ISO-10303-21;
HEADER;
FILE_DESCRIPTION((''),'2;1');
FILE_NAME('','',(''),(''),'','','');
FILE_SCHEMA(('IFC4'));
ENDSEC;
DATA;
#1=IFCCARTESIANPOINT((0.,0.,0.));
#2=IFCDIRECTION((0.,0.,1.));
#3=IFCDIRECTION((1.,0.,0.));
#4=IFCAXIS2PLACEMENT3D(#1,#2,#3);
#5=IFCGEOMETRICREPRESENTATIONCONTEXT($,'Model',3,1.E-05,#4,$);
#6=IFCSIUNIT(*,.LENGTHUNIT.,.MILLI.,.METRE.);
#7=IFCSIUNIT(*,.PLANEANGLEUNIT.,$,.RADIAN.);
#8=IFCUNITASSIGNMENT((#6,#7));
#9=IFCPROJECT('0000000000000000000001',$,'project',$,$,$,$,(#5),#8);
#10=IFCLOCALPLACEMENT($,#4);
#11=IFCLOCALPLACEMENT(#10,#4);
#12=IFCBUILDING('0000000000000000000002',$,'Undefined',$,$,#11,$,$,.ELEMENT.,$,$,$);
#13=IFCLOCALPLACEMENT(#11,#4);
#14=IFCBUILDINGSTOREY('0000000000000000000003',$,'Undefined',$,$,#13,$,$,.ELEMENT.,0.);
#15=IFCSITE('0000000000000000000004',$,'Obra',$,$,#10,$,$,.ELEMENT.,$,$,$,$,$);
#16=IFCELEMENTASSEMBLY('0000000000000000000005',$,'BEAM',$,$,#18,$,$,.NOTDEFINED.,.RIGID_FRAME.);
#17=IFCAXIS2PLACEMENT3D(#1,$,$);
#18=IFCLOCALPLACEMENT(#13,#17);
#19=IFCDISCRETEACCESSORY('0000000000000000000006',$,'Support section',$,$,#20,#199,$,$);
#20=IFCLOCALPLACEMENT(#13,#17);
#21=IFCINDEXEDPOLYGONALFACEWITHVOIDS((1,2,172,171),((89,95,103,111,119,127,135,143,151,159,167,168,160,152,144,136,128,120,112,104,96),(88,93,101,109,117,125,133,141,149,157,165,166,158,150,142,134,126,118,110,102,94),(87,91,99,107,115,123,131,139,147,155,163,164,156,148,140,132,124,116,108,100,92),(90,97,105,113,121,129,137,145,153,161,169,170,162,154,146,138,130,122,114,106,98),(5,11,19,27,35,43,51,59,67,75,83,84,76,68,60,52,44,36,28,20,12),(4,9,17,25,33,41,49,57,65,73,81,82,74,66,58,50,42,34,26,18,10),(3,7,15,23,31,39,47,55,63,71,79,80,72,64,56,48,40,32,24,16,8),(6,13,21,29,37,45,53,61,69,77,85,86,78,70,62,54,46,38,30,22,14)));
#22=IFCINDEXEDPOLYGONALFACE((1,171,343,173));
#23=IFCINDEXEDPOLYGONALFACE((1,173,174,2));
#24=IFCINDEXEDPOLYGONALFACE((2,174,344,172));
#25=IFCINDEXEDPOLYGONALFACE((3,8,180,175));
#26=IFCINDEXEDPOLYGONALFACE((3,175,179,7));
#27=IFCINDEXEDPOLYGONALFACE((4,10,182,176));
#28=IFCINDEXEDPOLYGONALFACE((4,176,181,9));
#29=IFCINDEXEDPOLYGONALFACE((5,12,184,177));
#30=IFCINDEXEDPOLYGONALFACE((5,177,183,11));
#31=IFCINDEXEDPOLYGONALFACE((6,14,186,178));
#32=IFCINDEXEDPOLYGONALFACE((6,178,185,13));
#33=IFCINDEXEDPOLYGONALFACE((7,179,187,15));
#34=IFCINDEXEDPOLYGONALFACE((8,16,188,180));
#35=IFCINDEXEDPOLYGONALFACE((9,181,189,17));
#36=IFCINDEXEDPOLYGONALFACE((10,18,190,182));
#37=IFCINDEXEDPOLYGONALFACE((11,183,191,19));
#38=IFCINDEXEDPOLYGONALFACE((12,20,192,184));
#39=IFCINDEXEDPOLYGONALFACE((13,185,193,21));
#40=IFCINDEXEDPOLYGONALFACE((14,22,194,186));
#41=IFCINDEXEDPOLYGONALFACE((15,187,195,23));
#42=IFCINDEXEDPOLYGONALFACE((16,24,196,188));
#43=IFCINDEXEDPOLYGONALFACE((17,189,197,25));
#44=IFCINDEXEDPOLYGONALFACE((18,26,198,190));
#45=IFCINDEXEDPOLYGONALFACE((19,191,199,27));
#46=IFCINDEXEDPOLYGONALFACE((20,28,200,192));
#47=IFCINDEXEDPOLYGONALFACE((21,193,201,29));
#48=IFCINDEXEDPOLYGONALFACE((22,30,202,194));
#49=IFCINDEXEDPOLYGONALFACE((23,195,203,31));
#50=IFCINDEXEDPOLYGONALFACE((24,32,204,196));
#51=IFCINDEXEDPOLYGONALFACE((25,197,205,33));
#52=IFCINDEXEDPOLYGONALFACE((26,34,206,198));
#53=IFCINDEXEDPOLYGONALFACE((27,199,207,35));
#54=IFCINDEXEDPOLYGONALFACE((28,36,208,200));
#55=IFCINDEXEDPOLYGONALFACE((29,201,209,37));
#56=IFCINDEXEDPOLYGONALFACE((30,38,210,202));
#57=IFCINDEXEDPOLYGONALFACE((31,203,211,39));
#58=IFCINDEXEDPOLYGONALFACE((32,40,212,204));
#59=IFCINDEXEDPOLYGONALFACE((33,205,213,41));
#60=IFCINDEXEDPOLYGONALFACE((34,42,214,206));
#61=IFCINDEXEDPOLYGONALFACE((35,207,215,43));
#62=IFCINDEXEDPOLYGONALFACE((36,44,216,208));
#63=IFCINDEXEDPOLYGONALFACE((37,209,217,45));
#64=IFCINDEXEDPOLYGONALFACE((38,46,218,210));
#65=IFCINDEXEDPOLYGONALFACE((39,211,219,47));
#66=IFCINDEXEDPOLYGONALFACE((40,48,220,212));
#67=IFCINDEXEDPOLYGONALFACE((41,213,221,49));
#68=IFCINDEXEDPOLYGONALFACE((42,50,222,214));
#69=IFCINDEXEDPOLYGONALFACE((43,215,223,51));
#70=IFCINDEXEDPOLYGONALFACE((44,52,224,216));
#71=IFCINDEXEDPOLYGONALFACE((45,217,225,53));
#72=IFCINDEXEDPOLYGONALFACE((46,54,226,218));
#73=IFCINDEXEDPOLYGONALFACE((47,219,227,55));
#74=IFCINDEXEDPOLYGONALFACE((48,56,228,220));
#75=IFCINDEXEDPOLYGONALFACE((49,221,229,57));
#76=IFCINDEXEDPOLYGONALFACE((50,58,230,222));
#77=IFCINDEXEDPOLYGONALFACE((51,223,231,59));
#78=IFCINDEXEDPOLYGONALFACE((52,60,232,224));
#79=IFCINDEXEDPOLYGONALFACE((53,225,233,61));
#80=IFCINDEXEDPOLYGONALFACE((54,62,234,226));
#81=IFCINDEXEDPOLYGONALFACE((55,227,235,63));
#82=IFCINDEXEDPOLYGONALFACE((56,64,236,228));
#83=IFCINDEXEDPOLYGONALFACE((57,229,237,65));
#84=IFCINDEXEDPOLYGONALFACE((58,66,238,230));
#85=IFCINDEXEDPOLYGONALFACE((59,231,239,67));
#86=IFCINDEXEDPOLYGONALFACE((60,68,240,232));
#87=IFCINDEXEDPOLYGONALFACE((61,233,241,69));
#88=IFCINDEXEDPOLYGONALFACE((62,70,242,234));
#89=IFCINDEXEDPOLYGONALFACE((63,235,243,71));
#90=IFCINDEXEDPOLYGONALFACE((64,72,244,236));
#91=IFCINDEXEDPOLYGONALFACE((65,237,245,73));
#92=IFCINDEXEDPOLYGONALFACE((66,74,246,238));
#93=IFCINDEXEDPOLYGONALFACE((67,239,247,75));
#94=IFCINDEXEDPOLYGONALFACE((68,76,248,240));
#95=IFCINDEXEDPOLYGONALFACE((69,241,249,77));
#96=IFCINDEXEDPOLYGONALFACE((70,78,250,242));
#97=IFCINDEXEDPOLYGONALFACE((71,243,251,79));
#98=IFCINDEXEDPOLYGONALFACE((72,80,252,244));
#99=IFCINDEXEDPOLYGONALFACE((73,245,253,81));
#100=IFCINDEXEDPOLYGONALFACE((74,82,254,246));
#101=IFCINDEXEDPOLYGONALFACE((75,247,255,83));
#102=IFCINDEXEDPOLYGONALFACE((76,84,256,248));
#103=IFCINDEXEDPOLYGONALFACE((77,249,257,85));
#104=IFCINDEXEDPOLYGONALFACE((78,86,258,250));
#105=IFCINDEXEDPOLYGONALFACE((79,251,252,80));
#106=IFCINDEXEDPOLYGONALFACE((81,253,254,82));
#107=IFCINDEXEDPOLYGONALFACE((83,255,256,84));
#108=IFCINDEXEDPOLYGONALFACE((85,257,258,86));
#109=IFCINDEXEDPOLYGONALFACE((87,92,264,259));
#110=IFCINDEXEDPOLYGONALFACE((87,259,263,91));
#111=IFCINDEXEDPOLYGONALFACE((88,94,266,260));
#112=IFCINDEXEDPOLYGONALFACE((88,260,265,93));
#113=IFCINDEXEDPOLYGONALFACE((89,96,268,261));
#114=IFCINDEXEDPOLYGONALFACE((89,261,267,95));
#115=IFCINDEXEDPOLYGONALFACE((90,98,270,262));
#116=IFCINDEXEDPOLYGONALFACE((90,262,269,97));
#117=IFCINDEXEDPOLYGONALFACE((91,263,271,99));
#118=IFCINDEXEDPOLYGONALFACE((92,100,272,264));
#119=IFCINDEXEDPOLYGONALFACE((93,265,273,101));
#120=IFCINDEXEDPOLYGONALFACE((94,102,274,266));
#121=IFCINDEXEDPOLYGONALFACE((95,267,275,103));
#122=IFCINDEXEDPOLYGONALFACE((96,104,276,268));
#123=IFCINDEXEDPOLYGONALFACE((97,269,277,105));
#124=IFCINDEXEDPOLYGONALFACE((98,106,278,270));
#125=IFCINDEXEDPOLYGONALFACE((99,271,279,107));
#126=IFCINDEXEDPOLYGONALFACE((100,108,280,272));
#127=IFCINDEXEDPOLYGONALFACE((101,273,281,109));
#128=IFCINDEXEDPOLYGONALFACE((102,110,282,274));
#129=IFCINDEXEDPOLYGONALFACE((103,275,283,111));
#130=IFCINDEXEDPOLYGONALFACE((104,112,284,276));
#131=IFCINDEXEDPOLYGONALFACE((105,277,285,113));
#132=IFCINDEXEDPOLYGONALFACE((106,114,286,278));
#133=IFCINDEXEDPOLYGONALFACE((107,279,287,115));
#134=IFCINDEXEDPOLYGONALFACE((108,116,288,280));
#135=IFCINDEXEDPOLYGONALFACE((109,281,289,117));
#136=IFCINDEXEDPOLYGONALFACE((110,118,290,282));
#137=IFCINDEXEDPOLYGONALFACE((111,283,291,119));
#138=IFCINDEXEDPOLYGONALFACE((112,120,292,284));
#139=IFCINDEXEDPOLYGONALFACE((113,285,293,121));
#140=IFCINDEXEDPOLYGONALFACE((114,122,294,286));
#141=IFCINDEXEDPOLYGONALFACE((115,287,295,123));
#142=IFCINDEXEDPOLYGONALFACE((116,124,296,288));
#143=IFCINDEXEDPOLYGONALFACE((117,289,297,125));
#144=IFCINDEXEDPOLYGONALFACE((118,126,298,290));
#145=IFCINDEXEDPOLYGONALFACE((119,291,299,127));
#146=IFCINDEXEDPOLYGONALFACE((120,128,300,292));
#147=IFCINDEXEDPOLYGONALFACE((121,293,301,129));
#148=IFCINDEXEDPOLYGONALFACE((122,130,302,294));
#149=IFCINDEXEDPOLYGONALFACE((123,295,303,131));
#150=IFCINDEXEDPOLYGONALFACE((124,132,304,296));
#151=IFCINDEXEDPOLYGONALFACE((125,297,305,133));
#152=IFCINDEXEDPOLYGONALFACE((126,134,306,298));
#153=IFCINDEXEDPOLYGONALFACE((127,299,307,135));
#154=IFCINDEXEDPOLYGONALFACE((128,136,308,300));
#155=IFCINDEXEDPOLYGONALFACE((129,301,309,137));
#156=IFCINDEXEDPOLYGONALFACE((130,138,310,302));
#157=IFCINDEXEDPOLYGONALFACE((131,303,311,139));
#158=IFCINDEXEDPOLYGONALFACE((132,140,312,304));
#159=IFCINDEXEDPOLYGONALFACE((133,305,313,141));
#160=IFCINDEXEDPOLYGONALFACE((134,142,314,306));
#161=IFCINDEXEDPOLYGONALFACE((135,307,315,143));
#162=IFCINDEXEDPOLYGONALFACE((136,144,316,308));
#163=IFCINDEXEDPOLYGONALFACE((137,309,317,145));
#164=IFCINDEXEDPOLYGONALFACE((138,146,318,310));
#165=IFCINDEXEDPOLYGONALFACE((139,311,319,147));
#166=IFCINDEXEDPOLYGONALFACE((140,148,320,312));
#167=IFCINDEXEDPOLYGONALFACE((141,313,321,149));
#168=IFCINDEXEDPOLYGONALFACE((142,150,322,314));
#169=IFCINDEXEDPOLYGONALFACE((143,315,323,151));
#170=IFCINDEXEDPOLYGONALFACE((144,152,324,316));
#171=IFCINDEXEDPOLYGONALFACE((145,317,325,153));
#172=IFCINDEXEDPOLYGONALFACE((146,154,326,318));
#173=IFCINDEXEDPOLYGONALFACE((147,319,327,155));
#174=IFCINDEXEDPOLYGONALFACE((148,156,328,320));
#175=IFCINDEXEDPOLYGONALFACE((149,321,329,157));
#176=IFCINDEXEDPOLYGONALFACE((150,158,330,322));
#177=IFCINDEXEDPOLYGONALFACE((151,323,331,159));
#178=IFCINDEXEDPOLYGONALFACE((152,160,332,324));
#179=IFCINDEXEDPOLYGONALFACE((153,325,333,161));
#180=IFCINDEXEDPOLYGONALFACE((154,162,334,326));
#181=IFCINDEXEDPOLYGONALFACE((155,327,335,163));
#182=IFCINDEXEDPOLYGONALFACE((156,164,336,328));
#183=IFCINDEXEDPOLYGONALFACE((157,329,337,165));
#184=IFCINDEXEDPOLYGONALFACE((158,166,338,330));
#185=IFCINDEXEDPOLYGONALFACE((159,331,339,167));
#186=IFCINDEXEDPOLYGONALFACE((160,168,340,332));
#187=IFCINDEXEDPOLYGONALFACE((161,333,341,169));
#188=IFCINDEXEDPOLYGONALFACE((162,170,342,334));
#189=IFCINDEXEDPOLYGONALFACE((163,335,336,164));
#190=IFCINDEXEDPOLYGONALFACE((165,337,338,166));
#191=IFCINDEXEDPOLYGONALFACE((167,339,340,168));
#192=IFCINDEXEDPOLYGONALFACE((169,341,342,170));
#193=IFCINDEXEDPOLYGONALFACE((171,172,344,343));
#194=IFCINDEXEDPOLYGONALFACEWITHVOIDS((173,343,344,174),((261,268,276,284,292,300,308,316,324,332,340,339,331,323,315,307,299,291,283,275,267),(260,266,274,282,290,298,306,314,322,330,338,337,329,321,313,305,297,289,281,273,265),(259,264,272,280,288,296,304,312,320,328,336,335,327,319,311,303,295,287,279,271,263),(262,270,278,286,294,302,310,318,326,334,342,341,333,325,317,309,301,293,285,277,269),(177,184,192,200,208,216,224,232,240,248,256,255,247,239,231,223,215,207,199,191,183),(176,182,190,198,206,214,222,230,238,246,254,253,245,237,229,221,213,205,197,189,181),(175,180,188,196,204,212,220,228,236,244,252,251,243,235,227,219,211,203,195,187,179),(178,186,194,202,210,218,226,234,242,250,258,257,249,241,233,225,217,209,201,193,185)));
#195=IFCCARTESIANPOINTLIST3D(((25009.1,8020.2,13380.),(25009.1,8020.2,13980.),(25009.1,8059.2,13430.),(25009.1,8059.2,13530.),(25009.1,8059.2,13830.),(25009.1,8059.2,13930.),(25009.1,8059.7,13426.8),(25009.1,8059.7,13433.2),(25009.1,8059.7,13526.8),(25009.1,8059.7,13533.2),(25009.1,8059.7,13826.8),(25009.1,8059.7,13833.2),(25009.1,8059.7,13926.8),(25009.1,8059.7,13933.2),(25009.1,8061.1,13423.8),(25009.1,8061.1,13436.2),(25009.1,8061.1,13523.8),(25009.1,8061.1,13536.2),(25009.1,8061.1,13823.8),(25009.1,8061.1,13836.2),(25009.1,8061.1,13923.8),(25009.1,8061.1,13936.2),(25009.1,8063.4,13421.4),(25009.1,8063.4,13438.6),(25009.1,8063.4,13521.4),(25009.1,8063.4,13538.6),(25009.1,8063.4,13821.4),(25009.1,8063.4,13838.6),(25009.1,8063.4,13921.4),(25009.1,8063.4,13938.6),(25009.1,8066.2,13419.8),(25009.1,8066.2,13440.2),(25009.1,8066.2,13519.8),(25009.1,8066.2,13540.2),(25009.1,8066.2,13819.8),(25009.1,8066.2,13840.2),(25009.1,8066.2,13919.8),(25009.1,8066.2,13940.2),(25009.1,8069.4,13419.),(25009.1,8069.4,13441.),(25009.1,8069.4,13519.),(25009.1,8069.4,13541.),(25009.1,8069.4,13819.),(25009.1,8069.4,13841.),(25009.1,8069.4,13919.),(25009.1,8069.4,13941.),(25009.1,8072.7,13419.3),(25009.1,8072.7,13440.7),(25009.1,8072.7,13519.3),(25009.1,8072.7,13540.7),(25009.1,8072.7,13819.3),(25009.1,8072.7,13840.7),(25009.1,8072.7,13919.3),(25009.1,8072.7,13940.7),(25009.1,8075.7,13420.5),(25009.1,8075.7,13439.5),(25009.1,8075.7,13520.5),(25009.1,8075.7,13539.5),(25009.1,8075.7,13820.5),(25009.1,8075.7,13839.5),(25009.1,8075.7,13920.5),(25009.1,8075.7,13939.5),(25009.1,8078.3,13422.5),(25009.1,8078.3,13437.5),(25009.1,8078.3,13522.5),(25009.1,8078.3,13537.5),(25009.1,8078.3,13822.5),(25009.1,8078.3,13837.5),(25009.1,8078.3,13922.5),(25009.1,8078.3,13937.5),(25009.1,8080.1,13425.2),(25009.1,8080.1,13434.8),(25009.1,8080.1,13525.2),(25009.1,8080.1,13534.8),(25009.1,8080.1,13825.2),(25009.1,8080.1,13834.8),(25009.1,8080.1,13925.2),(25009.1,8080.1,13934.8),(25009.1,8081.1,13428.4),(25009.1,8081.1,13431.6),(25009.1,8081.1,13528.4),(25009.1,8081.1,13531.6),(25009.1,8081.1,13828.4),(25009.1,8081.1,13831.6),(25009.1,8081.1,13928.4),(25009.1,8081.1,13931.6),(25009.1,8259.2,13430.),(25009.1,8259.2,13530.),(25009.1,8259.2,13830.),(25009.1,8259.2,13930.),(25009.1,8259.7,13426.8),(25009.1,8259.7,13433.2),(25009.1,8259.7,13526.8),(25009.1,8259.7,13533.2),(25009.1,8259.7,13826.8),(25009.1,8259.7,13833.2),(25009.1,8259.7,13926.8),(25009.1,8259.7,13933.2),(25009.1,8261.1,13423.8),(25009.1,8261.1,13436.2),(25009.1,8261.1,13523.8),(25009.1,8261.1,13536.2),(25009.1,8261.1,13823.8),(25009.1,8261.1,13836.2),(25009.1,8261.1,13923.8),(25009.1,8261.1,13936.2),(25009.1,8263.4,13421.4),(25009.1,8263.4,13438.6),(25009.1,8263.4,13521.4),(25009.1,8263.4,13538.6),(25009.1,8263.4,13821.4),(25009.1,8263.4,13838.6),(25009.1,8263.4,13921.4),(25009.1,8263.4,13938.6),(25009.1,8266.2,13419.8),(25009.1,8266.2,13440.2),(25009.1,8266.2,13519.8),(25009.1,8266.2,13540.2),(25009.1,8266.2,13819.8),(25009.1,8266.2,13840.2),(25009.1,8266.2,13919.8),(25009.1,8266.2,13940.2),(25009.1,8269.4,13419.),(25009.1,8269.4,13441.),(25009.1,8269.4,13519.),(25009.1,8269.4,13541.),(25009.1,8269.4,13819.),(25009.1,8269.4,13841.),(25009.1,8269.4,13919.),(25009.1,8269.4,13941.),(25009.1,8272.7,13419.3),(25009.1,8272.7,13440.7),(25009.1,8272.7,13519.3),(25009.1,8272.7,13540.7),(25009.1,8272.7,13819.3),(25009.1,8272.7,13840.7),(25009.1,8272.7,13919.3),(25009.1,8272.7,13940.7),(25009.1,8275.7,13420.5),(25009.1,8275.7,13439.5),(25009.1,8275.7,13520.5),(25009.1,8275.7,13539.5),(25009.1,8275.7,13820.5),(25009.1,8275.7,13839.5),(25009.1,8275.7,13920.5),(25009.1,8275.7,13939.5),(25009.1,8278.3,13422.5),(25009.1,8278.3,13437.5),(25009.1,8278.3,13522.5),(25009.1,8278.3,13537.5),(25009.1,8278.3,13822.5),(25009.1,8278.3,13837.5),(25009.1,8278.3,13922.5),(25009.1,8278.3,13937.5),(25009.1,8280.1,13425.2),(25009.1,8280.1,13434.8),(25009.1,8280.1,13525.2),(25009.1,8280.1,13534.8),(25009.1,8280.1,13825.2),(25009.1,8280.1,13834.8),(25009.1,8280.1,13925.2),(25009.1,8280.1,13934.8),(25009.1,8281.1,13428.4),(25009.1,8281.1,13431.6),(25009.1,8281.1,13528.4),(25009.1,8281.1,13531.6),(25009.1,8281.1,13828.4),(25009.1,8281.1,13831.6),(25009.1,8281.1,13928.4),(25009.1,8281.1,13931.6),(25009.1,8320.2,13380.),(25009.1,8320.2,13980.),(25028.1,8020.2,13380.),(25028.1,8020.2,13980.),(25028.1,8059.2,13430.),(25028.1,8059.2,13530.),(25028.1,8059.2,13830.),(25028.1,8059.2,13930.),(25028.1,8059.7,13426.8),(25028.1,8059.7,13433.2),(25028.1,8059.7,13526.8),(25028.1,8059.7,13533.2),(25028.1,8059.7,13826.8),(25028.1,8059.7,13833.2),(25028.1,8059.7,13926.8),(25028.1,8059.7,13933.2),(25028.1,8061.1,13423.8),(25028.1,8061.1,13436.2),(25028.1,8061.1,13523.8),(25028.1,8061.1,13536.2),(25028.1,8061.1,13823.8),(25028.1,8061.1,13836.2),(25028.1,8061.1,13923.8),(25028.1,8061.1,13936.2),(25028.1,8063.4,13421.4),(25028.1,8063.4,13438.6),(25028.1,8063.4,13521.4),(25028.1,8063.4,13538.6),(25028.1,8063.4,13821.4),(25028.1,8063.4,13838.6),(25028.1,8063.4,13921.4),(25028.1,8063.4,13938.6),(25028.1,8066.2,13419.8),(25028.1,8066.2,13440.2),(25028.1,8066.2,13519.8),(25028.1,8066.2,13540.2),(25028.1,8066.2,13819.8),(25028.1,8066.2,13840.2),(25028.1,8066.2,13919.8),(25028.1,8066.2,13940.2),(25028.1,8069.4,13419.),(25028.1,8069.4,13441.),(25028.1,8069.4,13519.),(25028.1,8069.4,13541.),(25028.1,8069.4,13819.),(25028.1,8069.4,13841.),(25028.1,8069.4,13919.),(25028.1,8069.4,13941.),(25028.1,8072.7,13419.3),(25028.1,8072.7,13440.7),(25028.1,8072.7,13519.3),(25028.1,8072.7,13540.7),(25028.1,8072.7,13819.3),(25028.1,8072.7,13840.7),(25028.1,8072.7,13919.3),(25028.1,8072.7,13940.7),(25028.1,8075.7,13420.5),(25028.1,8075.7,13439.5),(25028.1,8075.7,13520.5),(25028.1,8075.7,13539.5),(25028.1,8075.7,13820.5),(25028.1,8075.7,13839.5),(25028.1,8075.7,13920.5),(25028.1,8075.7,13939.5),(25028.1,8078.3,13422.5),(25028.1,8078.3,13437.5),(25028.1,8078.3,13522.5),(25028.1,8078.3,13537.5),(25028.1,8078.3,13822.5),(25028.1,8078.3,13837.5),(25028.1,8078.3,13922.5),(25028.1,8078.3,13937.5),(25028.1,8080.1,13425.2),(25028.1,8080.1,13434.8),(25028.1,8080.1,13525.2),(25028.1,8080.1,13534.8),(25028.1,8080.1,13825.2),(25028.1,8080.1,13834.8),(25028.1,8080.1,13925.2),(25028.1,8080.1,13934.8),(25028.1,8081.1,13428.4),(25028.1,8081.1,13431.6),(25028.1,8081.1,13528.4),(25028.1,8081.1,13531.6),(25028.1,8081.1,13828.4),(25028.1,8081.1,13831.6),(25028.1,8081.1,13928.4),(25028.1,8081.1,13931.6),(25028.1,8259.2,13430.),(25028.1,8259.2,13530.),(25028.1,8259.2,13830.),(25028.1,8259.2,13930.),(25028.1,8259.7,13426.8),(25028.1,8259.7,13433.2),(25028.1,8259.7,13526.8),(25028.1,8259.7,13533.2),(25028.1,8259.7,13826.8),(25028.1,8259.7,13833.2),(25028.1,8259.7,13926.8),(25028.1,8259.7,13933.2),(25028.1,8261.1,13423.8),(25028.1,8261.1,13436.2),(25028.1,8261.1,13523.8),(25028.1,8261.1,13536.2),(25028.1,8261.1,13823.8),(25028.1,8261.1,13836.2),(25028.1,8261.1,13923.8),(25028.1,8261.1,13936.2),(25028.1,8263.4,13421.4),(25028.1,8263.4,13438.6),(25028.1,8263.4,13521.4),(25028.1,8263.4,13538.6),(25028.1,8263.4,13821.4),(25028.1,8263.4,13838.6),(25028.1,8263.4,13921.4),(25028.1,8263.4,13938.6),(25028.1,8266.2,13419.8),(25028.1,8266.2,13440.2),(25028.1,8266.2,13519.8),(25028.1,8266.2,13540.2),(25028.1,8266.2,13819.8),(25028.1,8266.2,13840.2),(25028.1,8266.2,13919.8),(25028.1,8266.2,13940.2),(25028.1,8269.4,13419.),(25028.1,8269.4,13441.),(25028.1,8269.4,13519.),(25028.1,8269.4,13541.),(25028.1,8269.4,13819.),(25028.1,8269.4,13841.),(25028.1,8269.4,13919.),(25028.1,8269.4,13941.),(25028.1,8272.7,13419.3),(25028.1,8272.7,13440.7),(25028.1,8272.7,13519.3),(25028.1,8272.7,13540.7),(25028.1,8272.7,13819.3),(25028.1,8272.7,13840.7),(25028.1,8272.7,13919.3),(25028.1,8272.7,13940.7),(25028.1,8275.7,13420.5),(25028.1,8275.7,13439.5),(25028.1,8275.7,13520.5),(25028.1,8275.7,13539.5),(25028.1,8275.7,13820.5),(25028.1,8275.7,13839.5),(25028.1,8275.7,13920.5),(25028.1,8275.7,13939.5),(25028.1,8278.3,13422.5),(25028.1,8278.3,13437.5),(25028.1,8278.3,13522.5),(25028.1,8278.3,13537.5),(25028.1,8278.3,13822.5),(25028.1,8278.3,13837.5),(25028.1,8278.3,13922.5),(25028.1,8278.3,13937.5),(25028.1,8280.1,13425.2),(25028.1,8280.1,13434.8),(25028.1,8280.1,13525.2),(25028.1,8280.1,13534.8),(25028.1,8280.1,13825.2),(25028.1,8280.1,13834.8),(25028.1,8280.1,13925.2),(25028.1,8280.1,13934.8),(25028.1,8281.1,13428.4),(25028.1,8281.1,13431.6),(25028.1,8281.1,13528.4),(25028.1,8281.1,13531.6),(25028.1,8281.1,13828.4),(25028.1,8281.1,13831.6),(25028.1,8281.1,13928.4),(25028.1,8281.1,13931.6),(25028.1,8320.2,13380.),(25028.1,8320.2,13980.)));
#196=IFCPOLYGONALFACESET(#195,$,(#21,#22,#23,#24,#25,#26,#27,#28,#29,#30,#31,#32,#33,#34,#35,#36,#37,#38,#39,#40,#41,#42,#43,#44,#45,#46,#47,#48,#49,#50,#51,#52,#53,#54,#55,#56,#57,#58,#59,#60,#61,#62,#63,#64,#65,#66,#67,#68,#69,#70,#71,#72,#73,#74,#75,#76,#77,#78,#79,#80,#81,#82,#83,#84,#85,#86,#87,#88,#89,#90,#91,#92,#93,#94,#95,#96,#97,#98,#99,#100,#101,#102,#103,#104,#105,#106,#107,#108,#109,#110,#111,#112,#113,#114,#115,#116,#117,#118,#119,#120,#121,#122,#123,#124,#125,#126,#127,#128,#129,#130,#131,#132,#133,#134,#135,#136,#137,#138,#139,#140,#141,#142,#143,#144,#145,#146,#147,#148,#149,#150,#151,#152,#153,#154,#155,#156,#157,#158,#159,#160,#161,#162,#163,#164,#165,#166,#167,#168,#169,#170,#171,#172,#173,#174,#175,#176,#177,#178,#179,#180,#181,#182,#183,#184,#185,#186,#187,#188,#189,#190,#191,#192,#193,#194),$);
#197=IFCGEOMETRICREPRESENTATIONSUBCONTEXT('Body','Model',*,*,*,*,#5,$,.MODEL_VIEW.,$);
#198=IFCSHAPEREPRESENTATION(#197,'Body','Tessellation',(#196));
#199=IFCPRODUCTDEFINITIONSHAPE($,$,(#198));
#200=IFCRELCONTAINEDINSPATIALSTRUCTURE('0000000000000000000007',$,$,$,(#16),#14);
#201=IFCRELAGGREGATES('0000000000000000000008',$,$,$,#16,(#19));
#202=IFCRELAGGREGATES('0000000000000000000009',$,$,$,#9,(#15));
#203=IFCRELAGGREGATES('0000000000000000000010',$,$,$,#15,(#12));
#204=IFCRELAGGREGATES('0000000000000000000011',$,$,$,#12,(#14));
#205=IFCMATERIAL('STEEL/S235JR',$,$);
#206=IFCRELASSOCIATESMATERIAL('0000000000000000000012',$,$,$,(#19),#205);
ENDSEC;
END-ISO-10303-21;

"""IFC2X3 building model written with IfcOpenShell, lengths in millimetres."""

from ifc_helpers import new_model, si_unit, frame, origin_with_axes, origin_2d_with_axis, place, context, subcontext, project, spatial, rectangle, circle, extrude, source, transform, mapped, material, element, aggregate, save


model = new_model("IFC2X3")

# Units and contexts
model_context = context("Model", 3, precision=1e-05, world=origin_with_axes())
body_context = subcontext(model_context, "Body", "Model", "MODEL_VIEW")
ifc_project = project(units=[si_unit("LENGTHUNIT", "METRE", prefix="MILLI"), si_unit("PLANEANGLEUNIT", "RADIAN")], contexts=[model_context])

# Site, building, storey
site_placement = place(None, origin_with_axes())
site = spatial("IfcSite", under=ifc_project, at=site_placement, Name="Obra", CompositionType="ELEMENT")
building_placement = place(site_placement, origin_with_axes())
building = spatial("IfcBuilding", under=site, at=building_placement, Name="Undefined", CompositionType="ELEMENT")
storey_placement = place(building_placement, origin_with_axes())
storey = spatial("IfcBuildingStorey", under=building, at=storey_placement, Name="Undefined", CompositionType="ELEMENT", Elevation=0.0)

# Shared definitions
ifc_material_1 = material(Name="STEEL/S235JR")

# Element assembly, discrete accessory, opening
assembly_1_placement = place(storey_placement, origin_with_axes())
assembly_1 = element("IfcElementAssembly", 1, at=assembly_1_placement, inside=storey, Name="BEAM", AssemblyPlace="NOTDEFINED", PredefinedType="RIGID_FRAME")
discrete_accessory_1_placement = place(assembly_1_placement, frame((25018.6, 8020.2, 13680.0), z_axis=(0.0, 0.0, 1.0), x_axis=(0.0, 1.0, 0.0)))
discrete_accessory_1 = element("IfcDiscreteAccessory", 2, at=discrete_accessory_1_placement, material=ifc_material_1, Name="Support section", context=body_context, shape_type="SweptSolid", body=[
    extrude(rectangle(XDim=19.0, YDim=600.0, at=origin_2d_with_axis()), frame((300.0, 0.0, 0.0), z_axis=(-1.0, 0.0, 0.0), x_axis=(0.0, -1.0, 0.0)), (0.0, 0.0, 1.0), 300.0),
])
shared_shape_1 = source(origin_with_axes(), body_context, "Body", "SweptSolid", [
    extrude(circle(Radius=11.0, at=origin_2d_with_axis()), frame((0.0, -0.1, 0.0), z_axis=(0.0, 1.0, 0.0), x_axis=(1.0, 0.0, 0.0)), (0.0, 0.0, 1.0), 19.2),
])
opening_1_placement = place(assembly_1_placement, frame((25009.1, 8320.2, 13680.0), z_axis=(0.0, 0.0, 1.0), x_axis=(0.0, -1.0, 0.0)))
element("IfcOpeningElement", 3, at=opening_1_placement, cuts=discrete_accessory_1, ObjectType="Opening", context=body_context, shape_type="MappedRepresentation", body=[
    mapped(shared_shape_1, transform((50.0, 0.0, -250.0))),
    mapped(shared_shape_1, transform((50.0, 0.0, -150.0))),
    mapped(shared_shape_1, transform((50.0, 0.0, 150.0))),
    mapped(shared_shape_1, transform((50.0, 0.0, 250.0))),
    mapped(shared_shape_1, transform((250.0, 0.0, -250.0))),
    mapped(shared_shape_1, transform((250.0, 0.0, -150.0))),
    mapped(shared_shape_1, transform((250.0, 0.0, 150.0))),
    mapped(shared_shape_1, transform((250.0, 0.0, 250.0))),
])

aggregate(assembly_1, [discrete_accessory_1])

save(model, "model.ifc")
